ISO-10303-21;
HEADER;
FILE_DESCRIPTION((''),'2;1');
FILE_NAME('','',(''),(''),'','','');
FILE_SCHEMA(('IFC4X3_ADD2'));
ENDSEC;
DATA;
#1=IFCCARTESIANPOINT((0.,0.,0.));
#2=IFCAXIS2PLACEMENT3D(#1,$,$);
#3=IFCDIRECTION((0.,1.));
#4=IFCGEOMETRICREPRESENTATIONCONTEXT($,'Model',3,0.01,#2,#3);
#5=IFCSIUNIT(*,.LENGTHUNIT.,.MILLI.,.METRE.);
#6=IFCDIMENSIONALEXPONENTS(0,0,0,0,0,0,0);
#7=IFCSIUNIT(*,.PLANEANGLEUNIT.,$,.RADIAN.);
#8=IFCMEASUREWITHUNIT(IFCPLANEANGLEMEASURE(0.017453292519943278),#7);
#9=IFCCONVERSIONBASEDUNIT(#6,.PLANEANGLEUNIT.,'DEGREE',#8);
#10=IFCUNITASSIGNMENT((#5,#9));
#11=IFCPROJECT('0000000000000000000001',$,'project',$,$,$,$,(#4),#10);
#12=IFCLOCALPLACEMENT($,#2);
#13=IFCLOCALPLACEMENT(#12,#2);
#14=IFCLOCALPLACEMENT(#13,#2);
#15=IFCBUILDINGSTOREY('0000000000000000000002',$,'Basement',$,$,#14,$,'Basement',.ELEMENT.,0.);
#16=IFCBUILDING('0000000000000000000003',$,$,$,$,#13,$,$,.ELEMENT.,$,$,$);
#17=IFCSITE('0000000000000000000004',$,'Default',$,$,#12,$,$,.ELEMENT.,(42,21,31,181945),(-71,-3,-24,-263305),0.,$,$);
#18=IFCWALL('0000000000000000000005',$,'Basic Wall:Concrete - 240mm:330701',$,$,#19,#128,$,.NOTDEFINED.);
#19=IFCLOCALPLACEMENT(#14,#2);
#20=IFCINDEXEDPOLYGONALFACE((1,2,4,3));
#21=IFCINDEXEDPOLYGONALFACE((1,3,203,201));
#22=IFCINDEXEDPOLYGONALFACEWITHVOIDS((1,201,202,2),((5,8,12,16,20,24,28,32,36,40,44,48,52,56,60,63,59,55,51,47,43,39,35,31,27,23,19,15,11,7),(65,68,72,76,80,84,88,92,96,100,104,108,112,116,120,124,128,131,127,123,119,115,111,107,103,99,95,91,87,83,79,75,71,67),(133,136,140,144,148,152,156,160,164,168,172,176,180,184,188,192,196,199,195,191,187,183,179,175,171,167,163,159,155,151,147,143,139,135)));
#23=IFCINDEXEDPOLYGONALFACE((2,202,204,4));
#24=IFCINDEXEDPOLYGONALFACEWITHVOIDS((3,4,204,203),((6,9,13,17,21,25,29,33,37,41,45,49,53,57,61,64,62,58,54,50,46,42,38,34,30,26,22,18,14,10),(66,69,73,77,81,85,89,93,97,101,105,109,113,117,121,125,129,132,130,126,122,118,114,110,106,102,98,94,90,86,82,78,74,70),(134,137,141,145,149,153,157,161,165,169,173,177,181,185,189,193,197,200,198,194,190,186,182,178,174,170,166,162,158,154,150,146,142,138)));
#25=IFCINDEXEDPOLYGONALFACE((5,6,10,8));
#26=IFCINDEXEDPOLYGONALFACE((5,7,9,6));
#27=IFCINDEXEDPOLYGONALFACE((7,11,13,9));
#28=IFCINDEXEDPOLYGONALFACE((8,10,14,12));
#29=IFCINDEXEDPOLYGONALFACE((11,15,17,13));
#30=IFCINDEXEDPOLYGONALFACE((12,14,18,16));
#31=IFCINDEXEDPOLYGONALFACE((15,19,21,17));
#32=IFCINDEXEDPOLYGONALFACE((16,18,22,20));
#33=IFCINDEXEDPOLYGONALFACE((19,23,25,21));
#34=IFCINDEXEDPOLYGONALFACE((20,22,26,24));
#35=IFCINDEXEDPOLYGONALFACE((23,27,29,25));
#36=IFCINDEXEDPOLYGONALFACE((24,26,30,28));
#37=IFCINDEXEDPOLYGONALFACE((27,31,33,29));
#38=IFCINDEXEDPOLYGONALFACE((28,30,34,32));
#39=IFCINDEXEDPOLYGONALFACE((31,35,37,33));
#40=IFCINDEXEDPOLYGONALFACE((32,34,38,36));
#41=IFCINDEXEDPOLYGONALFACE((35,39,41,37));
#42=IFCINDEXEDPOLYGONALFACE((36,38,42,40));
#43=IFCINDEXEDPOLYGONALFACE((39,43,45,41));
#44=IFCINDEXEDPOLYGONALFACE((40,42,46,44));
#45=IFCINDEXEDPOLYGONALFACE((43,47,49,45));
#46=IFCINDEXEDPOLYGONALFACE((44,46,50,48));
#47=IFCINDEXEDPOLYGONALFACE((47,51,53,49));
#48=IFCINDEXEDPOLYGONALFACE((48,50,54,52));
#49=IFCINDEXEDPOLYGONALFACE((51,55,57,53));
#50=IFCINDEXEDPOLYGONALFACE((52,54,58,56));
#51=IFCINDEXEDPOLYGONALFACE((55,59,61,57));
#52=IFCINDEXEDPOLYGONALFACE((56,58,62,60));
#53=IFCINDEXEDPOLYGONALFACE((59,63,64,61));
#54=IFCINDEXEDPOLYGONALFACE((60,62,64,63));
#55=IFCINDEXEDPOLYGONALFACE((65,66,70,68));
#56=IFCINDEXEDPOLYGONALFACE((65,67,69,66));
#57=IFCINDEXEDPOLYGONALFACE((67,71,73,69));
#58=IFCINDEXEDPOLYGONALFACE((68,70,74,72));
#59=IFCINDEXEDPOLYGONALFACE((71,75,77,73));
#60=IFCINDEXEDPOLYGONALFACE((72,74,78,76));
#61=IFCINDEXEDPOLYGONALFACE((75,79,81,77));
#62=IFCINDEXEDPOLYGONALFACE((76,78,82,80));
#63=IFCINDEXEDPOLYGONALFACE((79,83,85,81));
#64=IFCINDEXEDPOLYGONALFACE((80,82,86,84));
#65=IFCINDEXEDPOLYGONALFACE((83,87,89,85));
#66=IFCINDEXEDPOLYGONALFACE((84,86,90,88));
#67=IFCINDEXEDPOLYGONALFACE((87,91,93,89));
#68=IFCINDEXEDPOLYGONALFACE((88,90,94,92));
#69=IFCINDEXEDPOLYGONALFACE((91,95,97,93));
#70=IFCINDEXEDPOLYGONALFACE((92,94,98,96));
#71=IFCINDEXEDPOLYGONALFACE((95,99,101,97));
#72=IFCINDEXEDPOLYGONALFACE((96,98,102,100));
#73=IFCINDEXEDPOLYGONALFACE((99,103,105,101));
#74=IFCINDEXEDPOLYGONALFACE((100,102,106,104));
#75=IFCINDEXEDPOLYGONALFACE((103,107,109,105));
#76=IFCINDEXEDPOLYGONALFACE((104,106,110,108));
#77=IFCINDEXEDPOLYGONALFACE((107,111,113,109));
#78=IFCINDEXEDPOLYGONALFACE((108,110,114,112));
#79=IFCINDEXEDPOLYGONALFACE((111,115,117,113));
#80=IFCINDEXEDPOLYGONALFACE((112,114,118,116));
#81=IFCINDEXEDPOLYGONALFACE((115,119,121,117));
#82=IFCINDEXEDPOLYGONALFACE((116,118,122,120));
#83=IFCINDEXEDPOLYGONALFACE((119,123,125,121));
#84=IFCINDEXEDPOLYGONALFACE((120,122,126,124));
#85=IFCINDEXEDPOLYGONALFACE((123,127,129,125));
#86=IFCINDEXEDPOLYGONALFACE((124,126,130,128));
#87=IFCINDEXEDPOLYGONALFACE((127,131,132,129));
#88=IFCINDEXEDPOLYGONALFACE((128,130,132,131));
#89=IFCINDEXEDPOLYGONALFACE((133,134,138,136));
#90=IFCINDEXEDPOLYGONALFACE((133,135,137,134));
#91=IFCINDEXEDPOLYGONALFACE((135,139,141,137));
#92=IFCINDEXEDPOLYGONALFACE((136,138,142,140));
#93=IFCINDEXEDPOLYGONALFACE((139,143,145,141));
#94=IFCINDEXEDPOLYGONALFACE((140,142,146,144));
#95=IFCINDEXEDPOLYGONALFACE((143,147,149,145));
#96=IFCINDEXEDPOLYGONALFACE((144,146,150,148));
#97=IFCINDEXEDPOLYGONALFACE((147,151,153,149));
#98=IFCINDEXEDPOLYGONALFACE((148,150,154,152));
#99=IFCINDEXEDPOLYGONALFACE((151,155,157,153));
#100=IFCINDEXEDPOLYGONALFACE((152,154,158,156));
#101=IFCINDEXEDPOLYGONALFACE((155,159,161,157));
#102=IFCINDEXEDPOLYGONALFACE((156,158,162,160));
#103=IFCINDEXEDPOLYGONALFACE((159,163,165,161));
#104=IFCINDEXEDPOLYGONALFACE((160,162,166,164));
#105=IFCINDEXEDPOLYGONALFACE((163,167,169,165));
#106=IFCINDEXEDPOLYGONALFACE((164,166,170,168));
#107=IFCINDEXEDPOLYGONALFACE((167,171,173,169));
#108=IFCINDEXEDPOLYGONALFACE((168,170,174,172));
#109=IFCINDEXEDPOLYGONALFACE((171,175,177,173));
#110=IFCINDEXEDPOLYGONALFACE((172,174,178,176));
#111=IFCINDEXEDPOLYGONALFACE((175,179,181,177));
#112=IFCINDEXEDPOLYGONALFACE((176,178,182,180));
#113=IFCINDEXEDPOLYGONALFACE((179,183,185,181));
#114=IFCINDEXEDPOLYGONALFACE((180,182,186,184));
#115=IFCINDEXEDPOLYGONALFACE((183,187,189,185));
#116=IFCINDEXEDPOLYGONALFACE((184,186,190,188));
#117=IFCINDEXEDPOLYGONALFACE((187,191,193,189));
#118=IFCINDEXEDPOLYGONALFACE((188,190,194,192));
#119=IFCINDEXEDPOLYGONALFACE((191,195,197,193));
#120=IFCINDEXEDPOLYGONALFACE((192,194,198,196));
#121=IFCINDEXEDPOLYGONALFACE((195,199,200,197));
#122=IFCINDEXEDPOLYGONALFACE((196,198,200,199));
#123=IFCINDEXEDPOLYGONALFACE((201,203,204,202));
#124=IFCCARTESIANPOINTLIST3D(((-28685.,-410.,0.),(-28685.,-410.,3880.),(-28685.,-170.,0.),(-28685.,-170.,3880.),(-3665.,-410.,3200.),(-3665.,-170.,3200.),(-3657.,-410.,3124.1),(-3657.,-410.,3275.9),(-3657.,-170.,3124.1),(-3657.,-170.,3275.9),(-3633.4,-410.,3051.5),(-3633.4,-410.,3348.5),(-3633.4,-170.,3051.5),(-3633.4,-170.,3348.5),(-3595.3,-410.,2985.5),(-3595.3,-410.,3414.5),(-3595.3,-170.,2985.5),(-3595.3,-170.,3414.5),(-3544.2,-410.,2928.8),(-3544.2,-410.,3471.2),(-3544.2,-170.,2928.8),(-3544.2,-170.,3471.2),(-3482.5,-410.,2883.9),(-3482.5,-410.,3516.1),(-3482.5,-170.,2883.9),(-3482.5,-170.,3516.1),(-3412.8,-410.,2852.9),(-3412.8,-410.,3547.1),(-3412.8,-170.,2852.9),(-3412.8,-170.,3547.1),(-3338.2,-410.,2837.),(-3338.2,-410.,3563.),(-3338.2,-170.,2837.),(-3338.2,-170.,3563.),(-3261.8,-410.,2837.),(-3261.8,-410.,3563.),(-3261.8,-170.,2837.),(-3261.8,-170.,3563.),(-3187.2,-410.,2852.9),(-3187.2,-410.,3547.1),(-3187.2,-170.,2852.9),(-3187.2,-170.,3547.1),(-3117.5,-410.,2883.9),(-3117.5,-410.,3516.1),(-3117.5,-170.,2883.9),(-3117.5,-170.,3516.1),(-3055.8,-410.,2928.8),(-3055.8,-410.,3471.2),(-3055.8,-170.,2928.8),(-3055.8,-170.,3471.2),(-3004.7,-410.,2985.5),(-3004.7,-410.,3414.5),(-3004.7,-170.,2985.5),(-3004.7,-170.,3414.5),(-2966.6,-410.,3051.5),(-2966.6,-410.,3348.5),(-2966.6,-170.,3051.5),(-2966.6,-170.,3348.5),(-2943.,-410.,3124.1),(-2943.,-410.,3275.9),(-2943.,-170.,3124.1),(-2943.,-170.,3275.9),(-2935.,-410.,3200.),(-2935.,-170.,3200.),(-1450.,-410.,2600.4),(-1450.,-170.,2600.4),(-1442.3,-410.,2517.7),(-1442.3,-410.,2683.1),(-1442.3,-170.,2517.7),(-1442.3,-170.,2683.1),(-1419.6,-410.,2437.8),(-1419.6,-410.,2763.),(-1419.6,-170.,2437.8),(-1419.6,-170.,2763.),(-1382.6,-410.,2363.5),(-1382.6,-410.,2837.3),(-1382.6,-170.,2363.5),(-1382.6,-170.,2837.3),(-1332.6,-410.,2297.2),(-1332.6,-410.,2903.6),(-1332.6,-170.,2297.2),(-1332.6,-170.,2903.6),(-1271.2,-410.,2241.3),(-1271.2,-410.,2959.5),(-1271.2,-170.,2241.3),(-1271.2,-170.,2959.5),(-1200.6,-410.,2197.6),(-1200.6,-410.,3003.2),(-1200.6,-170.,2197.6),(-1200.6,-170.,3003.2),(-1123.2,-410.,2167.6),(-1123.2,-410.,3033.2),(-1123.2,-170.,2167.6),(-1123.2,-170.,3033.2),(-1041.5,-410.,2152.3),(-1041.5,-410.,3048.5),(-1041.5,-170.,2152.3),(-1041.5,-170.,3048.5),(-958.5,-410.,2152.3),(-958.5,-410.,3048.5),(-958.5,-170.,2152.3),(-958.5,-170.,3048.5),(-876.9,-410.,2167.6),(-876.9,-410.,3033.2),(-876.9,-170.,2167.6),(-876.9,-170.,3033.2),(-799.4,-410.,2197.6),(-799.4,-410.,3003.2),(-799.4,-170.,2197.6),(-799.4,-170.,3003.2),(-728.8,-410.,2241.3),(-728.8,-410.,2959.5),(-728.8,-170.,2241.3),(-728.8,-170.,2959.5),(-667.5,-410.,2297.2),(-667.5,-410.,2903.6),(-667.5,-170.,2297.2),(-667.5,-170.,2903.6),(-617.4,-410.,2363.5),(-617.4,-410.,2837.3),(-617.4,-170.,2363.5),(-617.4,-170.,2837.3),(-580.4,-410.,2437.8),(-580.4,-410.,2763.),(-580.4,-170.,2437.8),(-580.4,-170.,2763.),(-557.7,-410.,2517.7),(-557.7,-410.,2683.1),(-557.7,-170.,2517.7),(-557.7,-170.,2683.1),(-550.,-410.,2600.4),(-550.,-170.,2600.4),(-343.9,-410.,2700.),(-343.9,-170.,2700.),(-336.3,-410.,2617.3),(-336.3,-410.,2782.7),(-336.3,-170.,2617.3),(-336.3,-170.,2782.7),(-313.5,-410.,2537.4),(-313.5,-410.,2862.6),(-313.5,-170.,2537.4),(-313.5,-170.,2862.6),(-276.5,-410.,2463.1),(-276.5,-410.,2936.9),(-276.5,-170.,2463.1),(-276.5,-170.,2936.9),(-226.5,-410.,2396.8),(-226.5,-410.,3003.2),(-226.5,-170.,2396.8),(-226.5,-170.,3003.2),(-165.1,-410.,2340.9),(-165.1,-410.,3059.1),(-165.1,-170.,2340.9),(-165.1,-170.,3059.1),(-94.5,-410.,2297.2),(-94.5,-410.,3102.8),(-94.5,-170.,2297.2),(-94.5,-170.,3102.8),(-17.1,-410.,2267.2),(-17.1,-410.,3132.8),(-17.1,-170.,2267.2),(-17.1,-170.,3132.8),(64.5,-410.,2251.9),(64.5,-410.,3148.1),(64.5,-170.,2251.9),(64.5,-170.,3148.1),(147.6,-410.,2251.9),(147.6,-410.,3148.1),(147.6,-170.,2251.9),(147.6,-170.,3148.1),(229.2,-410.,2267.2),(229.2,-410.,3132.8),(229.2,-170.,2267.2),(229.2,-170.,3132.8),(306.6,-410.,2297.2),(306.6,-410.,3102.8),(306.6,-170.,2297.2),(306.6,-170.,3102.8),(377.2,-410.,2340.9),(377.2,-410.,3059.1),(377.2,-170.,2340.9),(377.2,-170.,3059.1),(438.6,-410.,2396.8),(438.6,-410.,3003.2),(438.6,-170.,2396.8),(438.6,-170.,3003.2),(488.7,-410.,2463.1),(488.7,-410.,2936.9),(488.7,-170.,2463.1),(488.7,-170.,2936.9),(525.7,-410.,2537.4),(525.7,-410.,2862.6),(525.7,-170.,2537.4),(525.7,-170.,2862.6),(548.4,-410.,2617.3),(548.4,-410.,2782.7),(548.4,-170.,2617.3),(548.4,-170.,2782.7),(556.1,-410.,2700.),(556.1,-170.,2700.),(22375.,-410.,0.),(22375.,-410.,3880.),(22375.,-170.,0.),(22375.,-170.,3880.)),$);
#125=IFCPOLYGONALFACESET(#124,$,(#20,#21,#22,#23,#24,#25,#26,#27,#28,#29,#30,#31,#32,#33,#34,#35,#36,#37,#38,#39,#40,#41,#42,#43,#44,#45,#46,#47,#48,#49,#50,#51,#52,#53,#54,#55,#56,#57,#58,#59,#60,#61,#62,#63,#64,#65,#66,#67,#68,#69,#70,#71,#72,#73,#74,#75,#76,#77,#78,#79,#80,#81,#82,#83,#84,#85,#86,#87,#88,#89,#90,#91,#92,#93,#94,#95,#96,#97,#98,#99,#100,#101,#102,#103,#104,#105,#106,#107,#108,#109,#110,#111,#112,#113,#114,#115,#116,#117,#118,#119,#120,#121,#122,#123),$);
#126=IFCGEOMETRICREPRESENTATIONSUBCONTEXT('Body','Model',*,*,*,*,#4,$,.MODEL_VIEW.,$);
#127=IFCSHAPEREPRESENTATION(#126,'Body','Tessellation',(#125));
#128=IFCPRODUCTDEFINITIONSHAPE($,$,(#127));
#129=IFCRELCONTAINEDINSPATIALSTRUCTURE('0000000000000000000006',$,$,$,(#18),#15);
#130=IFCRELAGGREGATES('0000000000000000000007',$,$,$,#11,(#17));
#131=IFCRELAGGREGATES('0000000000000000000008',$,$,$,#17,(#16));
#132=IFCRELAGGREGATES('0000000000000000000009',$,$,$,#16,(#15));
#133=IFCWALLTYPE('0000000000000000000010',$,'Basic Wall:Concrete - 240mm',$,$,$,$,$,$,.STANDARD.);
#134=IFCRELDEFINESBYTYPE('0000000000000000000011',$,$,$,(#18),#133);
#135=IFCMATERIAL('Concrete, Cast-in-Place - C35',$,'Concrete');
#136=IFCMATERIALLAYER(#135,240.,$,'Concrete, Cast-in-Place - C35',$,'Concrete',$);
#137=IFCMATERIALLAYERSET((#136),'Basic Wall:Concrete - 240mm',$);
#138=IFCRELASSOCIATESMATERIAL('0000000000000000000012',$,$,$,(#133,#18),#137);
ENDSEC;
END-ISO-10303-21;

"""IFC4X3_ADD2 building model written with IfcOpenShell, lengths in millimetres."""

from ifc_helpers import new_model, entity, si_unit, converted_unit, direction, frame, frame_2d, origin, origin_2d_with_axis, place, context, subcontext, project, spatial, rectangle, circle, extrude, material, layer, layer_set, type_object, element, save


model = new_model("IFC4X3_ADD2")

# Units and contexts
model_context = context("Model", 3, precision=0.01, world=origin(), true_north=direction((0.0, 1.0)))
body_context = subcontext(model_context, "Body", "Model", "MODEL_VIEW")
ifc_project = project(units=[si_unit("LENGTHUNIT", "METRE", prefix="MILLI"), converted_unit("PLANEANGLEUNIT", "DEGREE", entity("IfcPlaneAngleMeasure", 0.017453292519943278), si_unit("PLANEANGLEUNIT", "RADIAN"), dimensions=[0, 0, 0, 0, 0, 0, 0])], contexts=[model_context])

# Site, building, storey
site_placement = place(None, origin())
site = spatial("IfcSite", under=ifc_project, at=site_placement, Name="Default", CompositionType="ELEMENT", RefLatitude=(42, 21, 31, 181945), RefLongitude=(-71, -3, -24, -263305), RefElevation=0.0)
building_placement = place(site_placement, origin())
building = spatial("IfcBuilding", under=site, at=building_placement, CompositionType="ELEMENT")
storey_placement = place(building_placement, origin())
storey = spatial("IfcBuildingStorey", under=building, at=storey_placement, Name="Basement", LongName="Basement", CompositionType="ELEMENT", Elevation=0.0)

# Shared definitions
ifc_material = material(Name="Concrete, Cast-in-Place - C35", Category="Concrete")

# Wall, openings
ifc_layer_1 = layer(ifc_material, 240.0, Name="Concrete, Cast-in-Place - C35", Category="Concrete")
ifc_layer_set_1 = layer_set([ifc_layer_1], Name="Basic Wall:Concrete - 240mm")
wall_type_1 = type_object("IfcWallType", Name="Basic Wall:Concrete - 240mm", PredefinedType="STANDARD", material=ifc_layer_set_1)
wall_1_placement = place(storey_placement, frame((-28685.0, -290.0, 0.0)))
wall_1 = element("IfcWall", 1, at=wall_1_placement, inside=storey, type_object=wall_type_1, material=ifc_layer_set_1, Name="Basic Wall:Concrete - 240mm:330701", PredefinedType="NOTDEFINED", context=body_context, shape_type="SweptSolid", body=[
    extrude(rectangle(XDim=51060.0, YDim=240.0, at=frame_2d((25530.0, 0.0), x_axis=(-1.0, 0.0))), origin(), (0.0, 0.0, 1.0), 3880.0),
])
opening_1_placement = place(wall_1_placement, frame((28685.0, 290.0, 2950.0)))
element("IfcOpeningElement", 2, at=opening_1_placement, cuts=wall_1, PredefinedType="OPENING", context=body_context, shape_type="SweptSolid", body=[
    extrude(circle(Radius=250.0, at=origin_2d_with_axis()), frame((-3300.0, -540.0, 250.0), z_axis=(0.0, 1.0, 0.0), x_axis=(-1.0, 0.0, 0.0)), (0.0, 0.0, 1.0), 500.0),
])
opening_2_placement = place(wall_1_placement, frame((28685.0, 290.0, 2835.0)))
element("IfcOpeningElement", 3, at=opening_2_placement, cuts=wall_1, PredefinedType="OPENING", context=body_context, shape_type="SweptSolid", body=[
    extrude(circle(Radius=365.0, at=frame_2d((0.0, 0.0), x_axis=(1.0, 0.0))), frame((-3300.0, -540.0, 365.0), z_axis=(0.0, 1.0, 0.0), x_axis=(-1.0, 0.0, 0.0)), (0.0, 0.0, 1.0), 500.0),
])
opening_3_placement = place(wall_1_placement, frame((28685.0, 290.0, 2250.0)))
element("IfcOpeningElement", 4, at=opening_3_placement, cuts=wall_1, PredefinedType="OPENING", context=body_context, shape_type="SweptSolid", body=[
    extrude(circle(Radius=450.0, at=frame_2d((0.0, 0.0), x_axis=(1.0, 0.0))), frame((106.1, -540.0, 450.0), z_axis=(0.0, 1.0, 0.0), x_axis=(-1.0, 0.0, 0.0)), (0.0, 0.0, 1.0), 500.0),
])
opening_4_placement = place(wall_1_placement, frame((28685.0, 290.0, 2150.4)))
element("IfcOpeningElement", 5, at=opening_4_placement, cuts=wall_1, PredefinedType="OPENING", context=body_context, shape_type="SweptSolid", body=[
    extrude(circle(Radius=450.0, at=frame_2d((0.0, 0.0), x_axis=(1.0, 0.0))), frame((-1000.0, -540.0, 450.0), z_axis=(0.0, 1.0, 0.0), x_axis=(-1.0, 0.0, 0.0)), (0.0, 0.0, 1.0), 500.0),
])

save(model, "model.ifc")
